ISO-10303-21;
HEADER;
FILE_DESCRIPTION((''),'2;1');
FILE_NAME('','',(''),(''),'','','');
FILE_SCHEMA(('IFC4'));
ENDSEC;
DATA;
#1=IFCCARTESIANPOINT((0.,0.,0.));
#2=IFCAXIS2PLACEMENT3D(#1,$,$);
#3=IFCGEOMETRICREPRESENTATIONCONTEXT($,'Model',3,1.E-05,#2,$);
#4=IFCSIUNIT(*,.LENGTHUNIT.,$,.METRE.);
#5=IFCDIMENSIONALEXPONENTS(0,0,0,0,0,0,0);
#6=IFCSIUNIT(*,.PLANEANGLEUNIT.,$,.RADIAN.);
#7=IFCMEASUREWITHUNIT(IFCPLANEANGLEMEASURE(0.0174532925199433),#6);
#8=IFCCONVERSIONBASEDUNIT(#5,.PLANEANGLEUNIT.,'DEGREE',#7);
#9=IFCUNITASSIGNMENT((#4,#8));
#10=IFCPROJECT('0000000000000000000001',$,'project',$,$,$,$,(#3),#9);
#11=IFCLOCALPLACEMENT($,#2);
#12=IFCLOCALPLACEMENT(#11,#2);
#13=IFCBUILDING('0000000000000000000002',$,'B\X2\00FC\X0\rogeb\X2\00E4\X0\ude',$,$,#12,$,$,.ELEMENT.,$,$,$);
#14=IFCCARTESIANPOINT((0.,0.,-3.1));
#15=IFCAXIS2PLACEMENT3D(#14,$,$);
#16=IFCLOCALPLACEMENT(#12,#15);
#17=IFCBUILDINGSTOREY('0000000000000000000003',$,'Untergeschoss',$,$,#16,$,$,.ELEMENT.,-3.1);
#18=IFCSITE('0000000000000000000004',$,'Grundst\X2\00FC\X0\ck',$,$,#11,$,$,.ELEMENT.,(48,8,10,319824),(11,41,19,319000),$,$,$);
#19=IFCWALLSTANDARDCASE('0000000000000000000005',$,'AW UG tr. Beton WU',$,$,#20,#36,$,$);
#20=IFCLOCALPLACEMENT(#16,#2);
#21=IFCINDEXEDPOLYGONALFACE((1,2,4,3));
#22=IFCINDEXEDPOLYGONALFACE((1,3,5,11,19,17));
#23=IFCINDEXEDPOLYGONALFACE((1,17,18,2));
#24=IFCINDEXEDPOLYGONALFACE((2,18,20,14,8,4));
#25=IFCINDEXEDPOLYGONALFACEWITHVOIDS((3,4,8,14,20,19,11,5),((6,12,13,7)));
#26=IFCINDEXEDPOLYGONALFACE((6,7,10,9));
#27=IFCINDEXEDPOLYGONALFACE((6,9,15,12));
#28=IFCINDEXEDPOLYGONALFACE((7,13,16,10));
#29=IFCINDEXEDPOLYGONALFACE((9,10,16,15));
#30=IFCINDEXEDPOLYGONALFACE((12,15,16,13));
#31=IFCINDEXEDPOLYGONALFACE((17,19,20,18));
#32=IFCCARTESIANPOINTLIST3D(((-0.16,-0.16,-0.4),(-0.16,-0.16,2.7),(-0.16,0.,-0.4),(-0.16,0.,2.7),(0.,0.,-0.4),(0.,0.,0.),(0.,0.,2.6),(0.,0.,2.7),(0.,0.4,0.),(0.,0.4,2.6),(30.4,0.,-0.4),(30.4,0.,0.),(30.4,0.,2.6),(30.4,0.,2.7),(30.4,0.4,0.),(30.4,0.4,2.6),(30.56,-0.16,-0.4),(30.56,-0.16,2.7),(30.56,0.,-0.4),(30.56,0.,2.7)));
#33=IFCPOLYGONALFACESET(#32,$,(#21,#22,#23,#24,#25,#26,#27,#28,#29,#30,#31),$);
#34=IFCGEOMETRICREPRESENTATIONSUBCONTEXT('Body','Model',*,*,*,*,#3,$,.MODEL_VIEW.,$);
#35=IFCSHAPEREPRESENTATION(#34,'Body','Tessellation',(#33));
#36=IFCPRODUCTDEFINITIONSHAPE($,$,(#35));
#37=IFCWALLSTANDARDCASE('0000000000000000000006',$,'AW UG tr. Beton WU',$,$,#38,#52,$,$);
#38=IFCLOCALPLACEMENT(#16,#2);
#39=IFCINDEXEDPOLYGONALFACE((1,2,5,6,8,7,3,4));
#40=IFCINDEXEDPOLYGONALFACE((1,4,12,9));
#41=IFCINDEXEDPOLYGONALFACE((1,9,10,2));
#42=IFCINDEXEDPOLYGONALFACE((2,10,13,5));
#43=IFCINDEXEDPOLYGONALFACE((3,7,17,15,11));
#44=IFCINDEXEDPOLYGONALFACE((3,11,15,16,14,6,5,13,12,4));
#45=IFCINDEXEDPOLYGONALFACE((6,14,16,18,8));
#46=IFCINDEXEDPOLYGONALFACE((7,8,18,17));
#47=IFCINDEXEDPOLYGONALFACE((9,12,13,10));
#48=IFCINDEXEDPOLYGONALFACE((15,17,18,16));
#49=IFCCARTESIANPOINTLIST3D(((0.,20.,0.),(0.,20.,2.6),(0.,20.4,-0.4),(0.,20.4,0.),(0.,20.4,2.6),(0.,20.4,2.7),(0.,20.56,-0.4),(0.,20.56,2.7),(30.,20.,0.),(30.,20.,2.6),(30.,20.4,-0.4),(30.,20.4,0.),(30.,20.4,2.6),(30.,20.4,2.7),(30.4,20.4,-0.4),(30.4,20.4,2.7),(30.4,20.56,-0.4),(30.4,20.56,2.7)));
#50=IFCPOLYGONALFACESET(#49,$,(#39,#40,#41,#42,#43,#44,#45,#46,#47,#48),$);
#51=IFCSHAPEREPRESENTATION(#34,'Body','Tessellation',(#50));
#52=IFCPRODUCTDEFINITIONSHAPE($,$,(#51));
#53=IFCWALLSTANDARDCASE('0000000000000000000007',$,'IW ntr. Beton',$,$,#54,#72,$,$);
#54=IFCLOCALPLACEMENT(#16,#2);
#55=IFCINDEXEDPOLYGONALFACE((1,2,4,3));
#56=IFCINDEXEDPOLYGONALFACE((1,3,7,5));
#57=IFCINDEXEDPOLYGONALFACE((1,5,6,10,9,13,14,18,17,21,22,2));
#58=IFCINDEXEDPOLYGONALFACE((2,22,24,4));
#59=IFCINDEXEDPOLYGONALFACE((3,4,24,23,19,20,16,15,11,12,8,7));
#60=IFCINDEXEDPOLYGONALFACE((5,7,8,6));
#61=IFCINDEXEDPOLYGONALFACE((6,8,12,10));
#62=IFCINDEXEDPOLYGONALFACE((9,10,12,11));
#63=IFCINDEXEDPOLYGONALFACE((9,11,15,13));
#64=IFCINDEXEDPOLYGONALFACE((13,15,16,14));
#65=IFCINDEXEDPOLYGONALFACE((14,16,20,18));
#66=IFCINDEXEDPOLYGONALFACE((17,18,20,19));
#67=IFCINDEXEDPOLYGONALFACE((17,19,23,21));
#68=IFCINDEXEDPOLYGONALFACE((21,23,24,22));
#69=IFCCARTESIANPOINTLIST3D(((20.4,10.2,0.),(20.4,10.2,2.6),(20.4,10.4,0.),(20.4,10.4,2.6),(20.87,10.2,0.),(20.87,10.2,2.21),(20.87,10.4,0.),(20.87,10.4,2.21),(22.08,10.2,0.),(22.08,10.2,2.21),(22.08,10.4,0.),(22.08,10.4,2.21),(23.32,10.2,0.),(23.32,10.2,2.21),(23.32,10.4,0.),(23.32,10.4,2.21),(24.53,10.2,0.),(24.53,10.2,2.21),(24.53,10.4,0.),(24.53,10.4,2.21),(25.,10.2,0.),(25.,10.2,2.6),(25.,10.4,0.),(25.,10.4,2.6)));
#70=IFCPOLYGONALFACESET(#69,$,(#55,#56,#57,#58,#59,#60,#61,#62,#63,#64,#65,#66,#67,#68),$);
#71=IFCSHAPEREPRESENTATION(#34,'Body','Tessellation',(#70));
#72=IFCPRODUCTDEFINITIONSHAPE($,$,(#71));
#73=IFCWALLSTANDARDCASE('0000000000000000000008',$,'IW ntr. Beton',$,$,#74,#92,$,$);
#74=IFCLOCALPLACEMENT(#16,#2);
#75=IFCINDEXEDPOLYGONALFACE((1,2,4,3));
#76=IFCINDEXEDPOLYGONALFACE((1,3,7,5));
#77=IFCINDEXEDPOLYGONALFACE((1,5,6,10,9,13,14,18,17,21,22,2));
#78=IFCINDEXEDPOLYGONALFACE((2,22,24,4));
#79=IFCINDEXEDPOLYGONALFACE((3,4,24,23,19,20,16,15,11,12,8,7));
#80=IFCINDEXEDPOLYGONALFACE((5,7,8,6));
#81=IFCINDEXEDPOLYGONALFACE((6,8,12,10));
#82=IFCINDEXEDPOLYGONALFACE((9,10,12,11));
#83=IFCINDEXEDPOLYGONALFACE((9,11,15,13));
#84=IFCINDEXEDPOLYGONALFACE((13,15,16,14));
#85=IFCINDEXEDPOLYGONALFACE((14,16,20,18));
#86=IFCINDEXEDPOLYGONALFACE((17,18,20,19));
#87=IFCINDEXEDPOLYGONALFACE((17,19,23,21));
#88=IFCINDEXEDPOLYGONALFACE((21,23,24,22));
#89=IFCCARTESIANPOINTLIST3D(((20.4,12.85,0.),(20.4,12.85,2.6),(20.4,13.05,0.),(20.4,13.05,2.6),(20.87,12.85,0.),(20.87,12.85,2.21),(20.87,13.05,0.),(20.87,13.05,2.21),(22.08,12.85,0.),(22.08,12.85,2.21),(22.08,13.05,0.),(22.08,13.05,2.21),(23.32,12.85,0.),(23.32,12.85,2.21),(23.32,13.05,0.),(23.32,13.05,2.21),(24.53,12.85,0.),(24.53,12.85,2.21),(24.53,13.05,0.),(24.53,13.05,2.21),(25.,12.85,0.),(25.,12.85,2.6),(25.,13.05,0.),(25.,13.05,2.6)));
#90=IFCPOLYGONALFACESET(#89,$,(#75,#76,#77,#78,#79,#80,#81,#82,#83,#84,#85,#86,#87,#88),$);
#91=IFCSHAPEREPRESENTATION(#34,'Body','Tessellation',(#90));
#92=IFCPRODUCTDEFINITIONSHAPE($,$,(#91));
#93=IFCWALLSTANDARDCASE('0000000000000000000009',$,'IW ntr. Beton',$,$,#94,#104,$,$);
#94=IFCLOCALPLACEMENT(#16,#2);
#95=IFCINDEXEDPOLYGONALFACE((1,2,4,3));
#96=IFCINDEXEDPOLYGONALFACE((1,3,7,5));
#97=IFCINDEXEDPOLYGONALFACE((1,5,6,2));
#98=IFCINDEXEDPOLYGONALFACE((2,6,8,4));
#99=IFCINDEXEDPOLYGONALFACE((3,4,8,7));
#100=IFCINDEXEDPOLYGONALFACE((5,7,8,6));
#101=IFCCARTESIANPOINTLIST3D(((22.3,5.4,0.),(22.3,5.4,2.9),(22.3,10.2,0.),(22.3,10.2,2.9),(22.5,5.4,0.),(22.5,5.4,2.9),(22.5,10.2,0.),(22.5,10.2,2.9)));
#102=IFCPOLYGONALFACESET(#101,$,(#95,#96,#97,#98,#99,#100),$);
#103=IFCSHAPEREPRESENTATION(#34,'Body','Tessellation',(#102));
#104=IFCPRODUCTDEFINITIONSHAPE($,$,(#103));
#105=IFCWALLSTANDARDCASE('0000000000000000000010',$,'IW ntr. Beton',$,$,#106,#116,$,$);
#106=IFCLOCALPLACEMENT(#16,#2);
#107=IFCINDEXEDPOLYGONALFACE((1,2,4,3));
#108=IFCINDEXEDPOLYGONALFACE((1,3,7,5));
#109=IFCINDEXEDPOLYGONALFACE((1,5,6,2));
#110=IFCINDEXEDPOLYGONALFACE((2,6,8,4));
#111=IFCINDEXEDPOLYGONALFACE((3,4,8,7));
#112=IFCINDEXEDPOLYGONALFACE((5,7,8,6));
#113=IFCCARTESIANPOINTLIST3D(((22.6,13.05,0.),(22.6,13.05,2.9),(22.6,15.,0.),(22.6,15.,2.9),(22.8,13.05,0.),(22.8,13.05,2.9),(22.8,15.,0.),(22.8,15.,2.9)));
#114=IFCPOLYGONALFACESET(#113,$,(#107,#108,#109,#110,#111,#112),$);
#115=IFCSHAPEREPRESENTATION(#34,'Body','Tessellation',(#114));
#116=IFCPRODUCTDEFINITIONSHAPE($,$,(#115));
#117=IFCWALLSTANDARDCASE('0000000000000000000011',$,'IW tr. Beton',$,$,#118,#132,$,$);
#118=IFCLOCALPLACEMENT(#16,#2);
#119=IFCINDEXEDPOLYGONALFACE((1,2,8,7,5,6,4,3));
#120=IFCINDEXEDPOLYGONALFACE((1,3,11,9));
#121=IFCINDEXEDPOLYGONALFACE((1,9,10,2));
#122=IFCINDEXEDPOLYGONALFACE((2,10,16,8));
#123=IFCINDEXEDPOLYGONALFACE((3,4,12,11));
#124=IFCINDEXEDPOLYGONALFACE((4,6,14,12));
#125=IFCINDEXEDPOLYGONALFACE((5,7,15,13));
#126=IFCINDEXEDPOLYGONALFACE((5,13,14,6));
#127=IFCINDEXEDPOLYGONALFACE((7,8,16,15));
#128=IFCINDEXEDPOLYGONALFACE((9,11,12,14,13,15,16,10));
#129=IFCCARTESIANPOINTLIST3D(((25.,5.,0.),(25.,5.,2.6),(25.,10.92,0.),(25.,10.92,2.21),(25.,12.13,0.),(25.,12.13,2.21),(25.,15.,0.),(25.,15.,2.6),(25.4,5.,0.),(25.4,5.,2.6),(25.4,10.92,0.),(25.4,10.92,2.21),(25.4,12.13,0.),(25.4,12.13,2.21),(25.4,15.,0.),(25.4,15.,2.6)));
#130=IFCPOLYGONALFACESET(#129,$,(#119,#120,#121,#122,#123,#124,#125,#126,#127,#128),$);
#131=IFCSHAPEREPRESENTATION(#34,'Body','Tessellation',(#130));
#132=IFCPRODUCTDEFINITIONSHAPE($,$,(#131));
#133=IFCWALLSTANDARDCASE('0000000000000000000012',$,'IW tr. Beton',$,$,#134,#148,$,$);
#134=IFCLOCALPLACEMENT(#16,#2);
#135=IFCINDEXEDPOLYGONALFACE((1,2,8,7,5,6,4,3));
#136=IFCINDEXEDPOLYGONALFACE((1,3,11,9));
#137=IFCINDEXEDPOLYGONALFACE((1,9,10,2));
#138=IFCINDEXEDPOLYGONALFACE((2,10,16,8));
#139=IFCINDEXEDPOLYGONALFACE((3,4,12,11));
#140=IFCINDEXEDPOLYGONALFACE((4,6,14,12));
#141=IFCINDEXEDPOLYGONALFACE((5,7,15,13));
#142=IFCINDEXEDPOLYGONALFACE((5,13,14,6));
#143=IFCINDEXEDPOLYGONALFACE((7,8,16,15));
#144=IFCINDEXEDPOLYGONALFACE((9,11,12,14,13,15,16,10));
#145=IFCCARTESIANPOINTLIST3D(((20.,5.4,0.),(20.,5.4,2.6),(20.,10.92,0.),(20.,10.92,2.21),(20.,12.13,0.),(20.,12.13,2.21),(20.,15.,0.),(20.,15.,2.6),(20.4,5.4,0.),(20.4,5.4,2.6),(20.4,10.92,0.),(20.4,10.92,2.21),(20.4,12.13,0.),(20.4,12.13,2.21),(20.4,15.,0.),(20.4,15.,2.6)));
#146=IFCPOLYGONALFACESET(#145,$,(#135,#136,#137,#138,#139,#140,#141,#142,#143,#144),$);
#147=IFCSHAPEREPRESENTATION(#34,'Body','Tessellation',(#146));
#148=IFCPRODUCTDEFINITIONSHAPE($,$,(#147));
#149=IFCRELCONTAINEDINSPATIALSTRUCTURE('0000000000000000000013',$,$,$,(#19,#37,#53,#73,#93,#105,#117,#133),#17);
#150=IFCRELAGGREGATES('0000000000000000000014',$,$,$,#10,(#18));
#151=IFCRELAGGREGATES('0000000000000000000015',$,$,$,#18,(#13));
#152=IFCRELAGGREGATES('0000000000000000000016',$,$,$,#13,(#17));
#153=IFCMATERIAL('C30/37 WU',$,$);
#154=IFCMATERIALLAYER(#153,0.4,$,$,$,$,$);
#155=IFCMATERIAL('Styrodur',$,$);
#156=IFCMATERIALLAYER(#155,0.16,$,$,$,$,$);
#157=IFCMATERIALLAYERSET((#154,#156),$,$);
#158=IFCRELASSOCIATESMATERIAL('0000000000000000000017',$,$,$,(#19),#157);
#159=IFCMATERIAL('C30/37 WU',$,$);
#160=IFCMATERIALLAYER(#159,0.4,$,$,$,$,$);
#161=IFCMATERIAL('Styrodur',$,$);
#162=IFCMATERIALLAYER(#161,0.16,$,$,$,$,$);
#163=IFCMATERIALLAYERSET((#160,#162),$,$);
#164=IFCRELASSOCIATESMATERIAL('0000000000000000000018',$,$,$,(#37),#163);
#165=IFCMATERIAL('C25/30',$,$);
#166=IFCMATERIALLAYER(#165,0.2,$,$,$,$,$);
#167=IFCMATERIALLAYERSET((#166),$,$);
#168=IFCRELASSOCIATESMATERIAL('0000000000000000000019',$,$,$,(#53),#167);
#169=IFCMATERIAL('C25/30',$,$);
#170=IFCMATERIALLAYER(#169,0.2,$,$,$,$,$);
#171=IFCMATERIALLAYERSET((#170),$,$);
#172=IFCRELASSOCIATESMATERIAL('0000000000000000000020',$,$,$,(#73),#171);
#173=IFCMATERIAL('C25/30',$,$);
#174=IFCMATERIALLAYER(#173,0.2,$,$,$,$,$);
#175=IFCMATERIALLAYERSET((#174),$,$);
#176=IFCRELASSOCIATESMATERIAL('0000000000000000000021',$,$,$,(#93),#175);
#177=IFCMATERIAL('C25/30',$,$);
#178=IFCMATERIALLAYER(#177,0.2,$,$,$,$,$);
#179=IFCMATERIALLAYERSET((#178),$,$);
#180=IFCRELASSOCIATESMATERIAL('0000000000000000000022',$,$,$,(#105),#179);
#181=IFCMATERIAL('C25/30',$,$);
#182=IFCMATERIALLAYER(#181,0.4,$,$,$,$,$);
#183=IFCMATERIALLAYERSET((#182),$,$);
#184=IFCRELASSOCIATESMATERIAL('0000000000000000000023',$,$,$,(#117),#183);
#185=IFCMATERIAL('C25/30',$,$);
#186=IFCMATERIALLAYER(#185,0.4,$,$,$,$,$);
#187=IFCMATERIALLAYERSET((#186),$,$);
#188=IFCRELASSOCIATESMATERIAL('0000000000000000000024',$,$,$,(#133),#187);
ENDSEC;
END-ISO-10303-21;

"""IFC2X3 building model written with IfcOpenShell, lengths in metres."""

from ifc_helpers import new_model, entity, si_unit, converted_unit, frame, frame_2d, origin, origin_with_axes, place, context, subcontext, project, spatial, polyline, rectangle, outline, extrude, clip, bounded_halfspace, material, layer, layer_set, layer_usage, element, save


model = new_model("IFC2X3")

# Units and contexts
model_context = context("Model", 3, precision=1e-05, world=origin())
body_context = subcontext(model_context, "Body", "Model", "MODEL_VIEW")
ifc_project = project(units=[si_unit("LENGTHUNIT", "METRE"), converted_unit("PLANEANGLEUNIT", "DEGREE", entity("IfcPlaneAngleMeasure", 0.0174532925199433), si_unit("PLANEANGLEUNIT", "RADIAN"), dimensions=[0, 0, 0, 0, 0, 0, 0])], contexts=[model_context])

# Site, building, storey
site_placement = place(None, origin())
site = spatial("IfcSite", under=ifc_project, at=site_placement, Name="Grundstück", CompositionType="ELEMENT", RefLatitude=(48, 8, 10, 319824), RefLongitude=(11, 41, 19, 319000))
building_placement = place(site_placement, origin())
building = spatial("IfcBuilding", under=site, at=building_placement, Name="Bürogebäude", CompositionType="ELEMENT")
storey_placement = place(building_placement, frame((0.0, 0.0, -3.1)))
storey = spatial("IfcBuildingStorey", under=building, at=storey_placement, Name="Untergeschoss", CompositionType="ELEMENT", Elevation=-3.1)

# Walls
ifc_material_1 = material(Name="C30/37 WU")
ifc_layer_1 = layer(ifc_material_1, 0.4)
ifc_material_2 = material(Name="Styrodur")
ifc_layer_2 = layer(ifc_material_2, 0.16)
ifc_layer_set_1 = layer_set([ifc_layer_1, ifc_layer_2])
ifc_layer_usage_1 = layer_usage(ifc_layer_set_1, "AXIS2", "POSITIVE", 0.0)
wall_1_placement = place(storey_placement, frame((30.4, 0.4, -0.4), z_axis=(0.0, 0.0, 1.0), x_axis=(-1.0, 0.0, 0.0)))
element("IfcWallStandardCase", 1, at=wall_1_placement, inside=storey, material=ifc_layer_usage_1, Name="AW UG tr. Beton WU", context=body_context, shape_type="Clipping", body=[
    clip(clip(extrude(outline(polyline([(-30.56, -0.56), (-0.16, -0.56), (-0.16, -0.16), (0.0, -0.16), (0.0, 0.0), (-30.72, 0.0), (-30.72, -0.16), (-30.56, -0.16), (-30.56, -0.56)])), frame((30.56, 0.56, 0.0), z_axis=(0.0, 0.0, 1.0), x_axis=(1.0, 0.0, 0.0)), (0.0, 0.0, 1.0), 3.1), bounded_halfspace(frame((15.2, 0.2, 0.4), z_axis=(0.0, 0.0, 1.0), x_axis=(0.0, -1.0, 0.0)), True, origin_with_axes(), polyline([(0.0, 0.4), (0.0, 0.0), (30.4, 0.0), (30.4, 0.4), (0.0, 0.4)]))), bounded_halfspace(frame((15.2, 0.2, 3.0), z_axis=(0.0, 0.0, -1.0), x_axis=(1.0, 0.0, 0.0)), True, origin_with_axes(), polyline([(0.0, 0.0), (30.4, 0.0), (30.4, 0.4), (0.0, 0.4), (0.0, 0.0)]))),
])
ifc_material_3 = material(Name="C30/37 WU")
ifc_layer_3 = layer(ifc_material_3, 0.4)
ifc_material_4 = material(Name="Styrodur")
ifc_layer_4 = layer(ifc_material_4, 0.16)
ifc_layer_set_2 = layer_set([ifc_layer_3, ifc_layer_4])
ifc_layer_usage_2 = layer_usage(ifc_layer_set_2, "AXIS2", "POSITIVE", 0.0)
wall_2_placement = place(storey_placement, frame((0.0, 20.0, -0.4)))
element("IfcWallStandardCase", 2, at=wall_2_placement, inside=storey, material=ifc_layer_usage_2, Name="AW UG tr. Beton WU", context=body_context, shape_type="Clipping", body=[
    clip(clip(extrude(outline(polyline([(0.0, 0.0), (30.0, 0.0), (30.0, 0.4), (30.4, 0.4), (30.4, 0.56), (0.0, 0.56), (0.0, 0.0)])), origin_with_axes(), (0.0, 0.0, 1.0), 3.1), bounded_halfspace(frame((15.0, 0.2, 0.4), z_axis=(0.0, 0.0, 1.0), x_axis=(0.0, -1.0, 0.0)), True, origin_with_axes(), polyline([(0.0, 0.4), (0.0, 0.0), (30.0, 0.0), (30.0, 0.4), (0.0, 0.4)]))), bounded_halfspace(frame((15.0, 0.2, 3.0), z_axis=(0.0, 0.0, -1.0), x_axis=(1.0, 0.0, 0.0)), True, origin_with_axes(), polyline([(0.0, 0.0), (30.0, 0.0), (30.0, 0.4), (0.0, 0.4), (0.0, 0.0)]))),
])

# Walls, openings
ifc_material_5 = material(Name="C25/30")
ifc_layer_5 = layer(ifc_material_5, 0.2)
ifc_layer_set_3 = layer_set([ifc_layer_5])
ifc_layer_usage_3 = layer_usage(ifc_layer_set_3, "AXIS2", "POSITIVE", -0.2)
wall_3_placement = place(storey_placement, frame((25.0, 10.4, 0.0), z_axis=(0.0, 0.0, 1.0), x_axis=(-1.0, 0.0, 0.0)))
wall_3 = element("IfcWallStandardCase", 3, at=wall_3_placement, inside=storey, material=ifc_layer_usage_3, Name="IW ntr. Beton", context=body_context, shape_type="SweptSolid", body=[
    extrude(rectangle(XDim=4.6, YDim=0.2, at=frame_2d((2.3, 0.1), x_axis=(1.0, 0.0))), origin_with_axes(), (0.0, 0.0, 1.0), 2.6),
])
opening_1_placement = place(wall_3_placement, frame((4.13, 0.2, 0.0), z_axis=(0.0, -1.0, 0.0), x_axis=(0.0, 0.0, 1.0)))
element("IfcOpeningElement", 4, at=opening_1_placement, cuts=wall_3, ObjectType="Opening", context=body_context, shape_type="SweptSolid", body=[
    extrude(outline(polyline([(0.0, 1.21), (2.21, 1.21), (2.21, 0.0), (0.0, 0.0), (0.0, 1.21)])), origin_with_axes(), (0.0, 0.0, 1.0), 0.2),
])
opening_2_placement = place(wall_3_placement, frame((1.68, 0.2, 0.0), z_axis=(0.0, -1.0, 0.0), x_axis=(0.0, 0.0, 1.0)))
element("IfcOpeningElement", 5, at=opening_2_placement, cuts=wall_3, ObjectType="Opening", context=body_context, shape_type="SweptSolid", body=[
    extrude(outline(polyline([(0.0, 1.21), (2.21, 1.21), (2.21, 0.0), (0.0, 0.0), (0.0, 1.21)])), origin_with_axes(), (0.0, 0.0, 1.0), 0.2),
])
ifc_material_6 = material(Name="C25/30")
ifc_layer_6 = layer(ifc_material_6, 0.2)
ifc_layer_set_4 = layer_set([ifc_layer_6])
ifc_layer_usage_4 = layer_usage(ifc_layer_set_4, "AXIS2", "POSITIVE", 0.0)
wall_4_placement = place(storey_placement, frame((25.0, 13.05, 0.0), z_axis=(0.0, 0.0, 1.0), x_axis=(-1.0, 0.0, 0.0)))
wall_4 = element("IfcWallStandardCase", 6, at=wall_4_placement, inside=storey, material=ifc_layer_usage_4, Name="IW ntr. Beton", context=body_context, shape_type="SweptSolid", body=[
    extrude(rectangle(XDim=4.6, YDim=0.2, at=frame_2d((2.3, 0.1), x_axis=(1.0, 0.0))), origin_with_axes(), (0.0, 0.0, 1.0), 2.6),
])
opening_3_placement = place(wall_4_placement, frame((1.68, 0.2, 0.0), z_axis=(0.0, -1.0, 0.0), x_axis=(0.0, 0.0, 1.0)))
element("IfcOpeningElement", 7, at=opening_3_placement, cuts=wall_4, ObjectType="Opening", context=body_context, shape_type="SweptSolid", body=[
    extrude(outline(polyline([(0.0, 1.21), (2.21, 1.21), (2.21, 0.0), (0.0, 0.0), (0.0, 1.21)])), origin_with_axes(), (0.0, 0.0, 1.0), 0.2),
])
opening_4_placement = place(wall_4_placement, frame((4.13, 0.2, 0.0), z_axis=(0.0, -1.0, 0.0), x_axis=(0.0, 0.0, 1.0)))
element("IfcOpeningElement", 8, at=opening_4_placement, cuts=wall_4, ObjectType="Opening", context=body_context, shape_type="SweptSolid", body=[
    extrude(outline(polyline([(0.0, 1.21), (2.21, 1.21), (2.21, 0.0), (0.0, 0.0), (0.0, 1.21)])), origin_with_axes(), (0.0, 0.0, 1.0), 0.2),
])

# Walls
ifc_material_7 = material(Name="C25/30")
ifc_layer_7 = layer(ifc_material_7, 0.2)
ifc_layer_set_5 = layer_set([ifc_layer_7])
ifc_layer_usage_5 = layer_usage(ifc_layer_set_5, "AXIS2", "POSITIVE", -0.2)
wall_5_placement = place(storey_placement, frame((22.3, 10.2, 0.0), z_axis=(0.0, 0.0, 1.0), x_axis=(0.0, -1.0, 0.0)))
element("IfcWallStandardCase", 9, at=wall_5_placement, inside=storey, material=ifc_layer_usage_5, Name="IW ntr. Beton", context=body_context, shape_type="SweptSolid", body=[
    extrude(rectangle(XDim=4.8, YDim=0.2, at=frame_2d((2.4, 0.1), x_axis=(1.0, 0.0))), origin_with_axes(), (0.0, 0.0, 1.0), 2.9),
])
ifc_material_8 = material(Name="C25/30")
ifc_layer_8 = layer(ifc_material_8, 0.2)
ifc_layer_set_6 = layer_set([ifc_layer_8])
ifc_layer_usage_6 = layer_usage(ifc_layer_set_6, "AXIS2", "POSITIVE", -0.1)
wall_6_placement = place(storey_placement, frame((22.6, 15.0, 0.0), z_axis=(0.0, 0.0, 1.0), x_axis=(0.0, -1.0, 0.0)))
element("IfcWallStandardCase", 10, at=wall_6_placement, inside=storey, material=ifc_layer_usage_6, Name="IW ntr. Beton", context=body_context, shape_type="SweptSolid", body=[
    extrude(rectangle(XDim=1.95, YDim=0.2, at=frame_2d((0.975, 0.1), x_axis=(1.0, 0.0))), origin_with_axes(), (0.0, 0.0, 1.0), 2.9),
])

# Walls, openings
ifc_material_9 = material(Name="C25/30")
ifc_layer_9 = layer(ifc_material_9, 0.4)
ifc_layer_set_7 = layer_set([ifc_layer_9])
ifc_layer_usage_7 = layer_usage(ifc_layer_set_7, "AXIS2", "POSITIVE", -0.2)
wall_7_placement = place(storey_placement, frame((25.0, 15.0, 0.0), z_axis=(0.0, 0.0, 1.0), x_axis=(0.0, -1.0, 0.0)))
wall_7 = element("IfcWallStandardCase", 11, at=wall_7_placement, inside=storey, material=ifc_layer_usage_7, Name="IW tr. Beton", context=body_context, shape_type="SweptSolid", body=[
    extrude(rectangle(XDim=10.0, YDim=0.4, at=frame_2d((5.0, 0.2), x_axis=(1.0, 0.0))), origin_with_axes(), (0.0, 0.0, 1.0), 2.6),
])
opening_5_placement = place(wall_7_placement, frame((2.87, 0.0, 0.0), z_axis=(0.0, 1.0, 0.0), x_axis=(0.0, 0.0, 1.0)))
element("IfcOpeningElement", 12, at=opening_5_placement, cuts=wall_7, ObjectType="Opening", context=body_context, shape_type="SweptSolid", body=[
    extrude(outline(polyline([(0.0, 1.21), (2.21, 1.21), (2.21, 0.0), (0.0, 0.0), (0.0, 1.21)])), origin_with_axes(), (0.0, 0.0, 1.0), 0.4),
])
ifc_material_10 = material(Name="C25/30")
ifc_layer_10 = layer(ifc_material_10, 0.4)
ifc_layer_set_8 = layer_set([ifc_layer_10])
ifc_layer_usage_8 = layer_usage(ifc_layer_set_8, "AXIS2", "POSITIVE", -0.2)
wall_8_placement = place(storey_placement, frame((20.4, 5.4, 0.0), z_axis=(0.0, 0.0, 1.0), x_axis=(0.0, 1.0, 0.0)))
wall_8 = element("IfcWallStandardCase", 13, at=wall_8_placement, inside=storey, material=ifc_layer_usage_8, Name="IW tr. Beton", context=body_context, shape_type="SweptSolid", body=[
    extrude(rectangle(XDim=9.6, YDim=0.4, at=frame_2d((4.8, 0.2), x_axis=(1.0, 0.0))), origin_with_axes(), (0.0, 0.0, 1.0), 2.6),
])
opening_6_placement = place(wall_8_placement, frame((5.52, 0.0, 0.0), z_axis=(0.0, 1.0, 0.0), x_axis=(0.0, 0.0, 1.0)))
element("IfcOpeningElement", 14, at=opening_6_placement, cuts=wall_8, ObjectType="Opening", context=body_context, shape_type="SweptSolid", body=[
    extrude(outline(polyline([(0.0, 1.21), (2.21, 1.21), (2.21, 0.0), (0.0, 0.0), (0.0, 1.21)])), origin_with_axes(), (0.0, 0.0, 1.0), 0.4),
])

save(model, "model.ifc")
